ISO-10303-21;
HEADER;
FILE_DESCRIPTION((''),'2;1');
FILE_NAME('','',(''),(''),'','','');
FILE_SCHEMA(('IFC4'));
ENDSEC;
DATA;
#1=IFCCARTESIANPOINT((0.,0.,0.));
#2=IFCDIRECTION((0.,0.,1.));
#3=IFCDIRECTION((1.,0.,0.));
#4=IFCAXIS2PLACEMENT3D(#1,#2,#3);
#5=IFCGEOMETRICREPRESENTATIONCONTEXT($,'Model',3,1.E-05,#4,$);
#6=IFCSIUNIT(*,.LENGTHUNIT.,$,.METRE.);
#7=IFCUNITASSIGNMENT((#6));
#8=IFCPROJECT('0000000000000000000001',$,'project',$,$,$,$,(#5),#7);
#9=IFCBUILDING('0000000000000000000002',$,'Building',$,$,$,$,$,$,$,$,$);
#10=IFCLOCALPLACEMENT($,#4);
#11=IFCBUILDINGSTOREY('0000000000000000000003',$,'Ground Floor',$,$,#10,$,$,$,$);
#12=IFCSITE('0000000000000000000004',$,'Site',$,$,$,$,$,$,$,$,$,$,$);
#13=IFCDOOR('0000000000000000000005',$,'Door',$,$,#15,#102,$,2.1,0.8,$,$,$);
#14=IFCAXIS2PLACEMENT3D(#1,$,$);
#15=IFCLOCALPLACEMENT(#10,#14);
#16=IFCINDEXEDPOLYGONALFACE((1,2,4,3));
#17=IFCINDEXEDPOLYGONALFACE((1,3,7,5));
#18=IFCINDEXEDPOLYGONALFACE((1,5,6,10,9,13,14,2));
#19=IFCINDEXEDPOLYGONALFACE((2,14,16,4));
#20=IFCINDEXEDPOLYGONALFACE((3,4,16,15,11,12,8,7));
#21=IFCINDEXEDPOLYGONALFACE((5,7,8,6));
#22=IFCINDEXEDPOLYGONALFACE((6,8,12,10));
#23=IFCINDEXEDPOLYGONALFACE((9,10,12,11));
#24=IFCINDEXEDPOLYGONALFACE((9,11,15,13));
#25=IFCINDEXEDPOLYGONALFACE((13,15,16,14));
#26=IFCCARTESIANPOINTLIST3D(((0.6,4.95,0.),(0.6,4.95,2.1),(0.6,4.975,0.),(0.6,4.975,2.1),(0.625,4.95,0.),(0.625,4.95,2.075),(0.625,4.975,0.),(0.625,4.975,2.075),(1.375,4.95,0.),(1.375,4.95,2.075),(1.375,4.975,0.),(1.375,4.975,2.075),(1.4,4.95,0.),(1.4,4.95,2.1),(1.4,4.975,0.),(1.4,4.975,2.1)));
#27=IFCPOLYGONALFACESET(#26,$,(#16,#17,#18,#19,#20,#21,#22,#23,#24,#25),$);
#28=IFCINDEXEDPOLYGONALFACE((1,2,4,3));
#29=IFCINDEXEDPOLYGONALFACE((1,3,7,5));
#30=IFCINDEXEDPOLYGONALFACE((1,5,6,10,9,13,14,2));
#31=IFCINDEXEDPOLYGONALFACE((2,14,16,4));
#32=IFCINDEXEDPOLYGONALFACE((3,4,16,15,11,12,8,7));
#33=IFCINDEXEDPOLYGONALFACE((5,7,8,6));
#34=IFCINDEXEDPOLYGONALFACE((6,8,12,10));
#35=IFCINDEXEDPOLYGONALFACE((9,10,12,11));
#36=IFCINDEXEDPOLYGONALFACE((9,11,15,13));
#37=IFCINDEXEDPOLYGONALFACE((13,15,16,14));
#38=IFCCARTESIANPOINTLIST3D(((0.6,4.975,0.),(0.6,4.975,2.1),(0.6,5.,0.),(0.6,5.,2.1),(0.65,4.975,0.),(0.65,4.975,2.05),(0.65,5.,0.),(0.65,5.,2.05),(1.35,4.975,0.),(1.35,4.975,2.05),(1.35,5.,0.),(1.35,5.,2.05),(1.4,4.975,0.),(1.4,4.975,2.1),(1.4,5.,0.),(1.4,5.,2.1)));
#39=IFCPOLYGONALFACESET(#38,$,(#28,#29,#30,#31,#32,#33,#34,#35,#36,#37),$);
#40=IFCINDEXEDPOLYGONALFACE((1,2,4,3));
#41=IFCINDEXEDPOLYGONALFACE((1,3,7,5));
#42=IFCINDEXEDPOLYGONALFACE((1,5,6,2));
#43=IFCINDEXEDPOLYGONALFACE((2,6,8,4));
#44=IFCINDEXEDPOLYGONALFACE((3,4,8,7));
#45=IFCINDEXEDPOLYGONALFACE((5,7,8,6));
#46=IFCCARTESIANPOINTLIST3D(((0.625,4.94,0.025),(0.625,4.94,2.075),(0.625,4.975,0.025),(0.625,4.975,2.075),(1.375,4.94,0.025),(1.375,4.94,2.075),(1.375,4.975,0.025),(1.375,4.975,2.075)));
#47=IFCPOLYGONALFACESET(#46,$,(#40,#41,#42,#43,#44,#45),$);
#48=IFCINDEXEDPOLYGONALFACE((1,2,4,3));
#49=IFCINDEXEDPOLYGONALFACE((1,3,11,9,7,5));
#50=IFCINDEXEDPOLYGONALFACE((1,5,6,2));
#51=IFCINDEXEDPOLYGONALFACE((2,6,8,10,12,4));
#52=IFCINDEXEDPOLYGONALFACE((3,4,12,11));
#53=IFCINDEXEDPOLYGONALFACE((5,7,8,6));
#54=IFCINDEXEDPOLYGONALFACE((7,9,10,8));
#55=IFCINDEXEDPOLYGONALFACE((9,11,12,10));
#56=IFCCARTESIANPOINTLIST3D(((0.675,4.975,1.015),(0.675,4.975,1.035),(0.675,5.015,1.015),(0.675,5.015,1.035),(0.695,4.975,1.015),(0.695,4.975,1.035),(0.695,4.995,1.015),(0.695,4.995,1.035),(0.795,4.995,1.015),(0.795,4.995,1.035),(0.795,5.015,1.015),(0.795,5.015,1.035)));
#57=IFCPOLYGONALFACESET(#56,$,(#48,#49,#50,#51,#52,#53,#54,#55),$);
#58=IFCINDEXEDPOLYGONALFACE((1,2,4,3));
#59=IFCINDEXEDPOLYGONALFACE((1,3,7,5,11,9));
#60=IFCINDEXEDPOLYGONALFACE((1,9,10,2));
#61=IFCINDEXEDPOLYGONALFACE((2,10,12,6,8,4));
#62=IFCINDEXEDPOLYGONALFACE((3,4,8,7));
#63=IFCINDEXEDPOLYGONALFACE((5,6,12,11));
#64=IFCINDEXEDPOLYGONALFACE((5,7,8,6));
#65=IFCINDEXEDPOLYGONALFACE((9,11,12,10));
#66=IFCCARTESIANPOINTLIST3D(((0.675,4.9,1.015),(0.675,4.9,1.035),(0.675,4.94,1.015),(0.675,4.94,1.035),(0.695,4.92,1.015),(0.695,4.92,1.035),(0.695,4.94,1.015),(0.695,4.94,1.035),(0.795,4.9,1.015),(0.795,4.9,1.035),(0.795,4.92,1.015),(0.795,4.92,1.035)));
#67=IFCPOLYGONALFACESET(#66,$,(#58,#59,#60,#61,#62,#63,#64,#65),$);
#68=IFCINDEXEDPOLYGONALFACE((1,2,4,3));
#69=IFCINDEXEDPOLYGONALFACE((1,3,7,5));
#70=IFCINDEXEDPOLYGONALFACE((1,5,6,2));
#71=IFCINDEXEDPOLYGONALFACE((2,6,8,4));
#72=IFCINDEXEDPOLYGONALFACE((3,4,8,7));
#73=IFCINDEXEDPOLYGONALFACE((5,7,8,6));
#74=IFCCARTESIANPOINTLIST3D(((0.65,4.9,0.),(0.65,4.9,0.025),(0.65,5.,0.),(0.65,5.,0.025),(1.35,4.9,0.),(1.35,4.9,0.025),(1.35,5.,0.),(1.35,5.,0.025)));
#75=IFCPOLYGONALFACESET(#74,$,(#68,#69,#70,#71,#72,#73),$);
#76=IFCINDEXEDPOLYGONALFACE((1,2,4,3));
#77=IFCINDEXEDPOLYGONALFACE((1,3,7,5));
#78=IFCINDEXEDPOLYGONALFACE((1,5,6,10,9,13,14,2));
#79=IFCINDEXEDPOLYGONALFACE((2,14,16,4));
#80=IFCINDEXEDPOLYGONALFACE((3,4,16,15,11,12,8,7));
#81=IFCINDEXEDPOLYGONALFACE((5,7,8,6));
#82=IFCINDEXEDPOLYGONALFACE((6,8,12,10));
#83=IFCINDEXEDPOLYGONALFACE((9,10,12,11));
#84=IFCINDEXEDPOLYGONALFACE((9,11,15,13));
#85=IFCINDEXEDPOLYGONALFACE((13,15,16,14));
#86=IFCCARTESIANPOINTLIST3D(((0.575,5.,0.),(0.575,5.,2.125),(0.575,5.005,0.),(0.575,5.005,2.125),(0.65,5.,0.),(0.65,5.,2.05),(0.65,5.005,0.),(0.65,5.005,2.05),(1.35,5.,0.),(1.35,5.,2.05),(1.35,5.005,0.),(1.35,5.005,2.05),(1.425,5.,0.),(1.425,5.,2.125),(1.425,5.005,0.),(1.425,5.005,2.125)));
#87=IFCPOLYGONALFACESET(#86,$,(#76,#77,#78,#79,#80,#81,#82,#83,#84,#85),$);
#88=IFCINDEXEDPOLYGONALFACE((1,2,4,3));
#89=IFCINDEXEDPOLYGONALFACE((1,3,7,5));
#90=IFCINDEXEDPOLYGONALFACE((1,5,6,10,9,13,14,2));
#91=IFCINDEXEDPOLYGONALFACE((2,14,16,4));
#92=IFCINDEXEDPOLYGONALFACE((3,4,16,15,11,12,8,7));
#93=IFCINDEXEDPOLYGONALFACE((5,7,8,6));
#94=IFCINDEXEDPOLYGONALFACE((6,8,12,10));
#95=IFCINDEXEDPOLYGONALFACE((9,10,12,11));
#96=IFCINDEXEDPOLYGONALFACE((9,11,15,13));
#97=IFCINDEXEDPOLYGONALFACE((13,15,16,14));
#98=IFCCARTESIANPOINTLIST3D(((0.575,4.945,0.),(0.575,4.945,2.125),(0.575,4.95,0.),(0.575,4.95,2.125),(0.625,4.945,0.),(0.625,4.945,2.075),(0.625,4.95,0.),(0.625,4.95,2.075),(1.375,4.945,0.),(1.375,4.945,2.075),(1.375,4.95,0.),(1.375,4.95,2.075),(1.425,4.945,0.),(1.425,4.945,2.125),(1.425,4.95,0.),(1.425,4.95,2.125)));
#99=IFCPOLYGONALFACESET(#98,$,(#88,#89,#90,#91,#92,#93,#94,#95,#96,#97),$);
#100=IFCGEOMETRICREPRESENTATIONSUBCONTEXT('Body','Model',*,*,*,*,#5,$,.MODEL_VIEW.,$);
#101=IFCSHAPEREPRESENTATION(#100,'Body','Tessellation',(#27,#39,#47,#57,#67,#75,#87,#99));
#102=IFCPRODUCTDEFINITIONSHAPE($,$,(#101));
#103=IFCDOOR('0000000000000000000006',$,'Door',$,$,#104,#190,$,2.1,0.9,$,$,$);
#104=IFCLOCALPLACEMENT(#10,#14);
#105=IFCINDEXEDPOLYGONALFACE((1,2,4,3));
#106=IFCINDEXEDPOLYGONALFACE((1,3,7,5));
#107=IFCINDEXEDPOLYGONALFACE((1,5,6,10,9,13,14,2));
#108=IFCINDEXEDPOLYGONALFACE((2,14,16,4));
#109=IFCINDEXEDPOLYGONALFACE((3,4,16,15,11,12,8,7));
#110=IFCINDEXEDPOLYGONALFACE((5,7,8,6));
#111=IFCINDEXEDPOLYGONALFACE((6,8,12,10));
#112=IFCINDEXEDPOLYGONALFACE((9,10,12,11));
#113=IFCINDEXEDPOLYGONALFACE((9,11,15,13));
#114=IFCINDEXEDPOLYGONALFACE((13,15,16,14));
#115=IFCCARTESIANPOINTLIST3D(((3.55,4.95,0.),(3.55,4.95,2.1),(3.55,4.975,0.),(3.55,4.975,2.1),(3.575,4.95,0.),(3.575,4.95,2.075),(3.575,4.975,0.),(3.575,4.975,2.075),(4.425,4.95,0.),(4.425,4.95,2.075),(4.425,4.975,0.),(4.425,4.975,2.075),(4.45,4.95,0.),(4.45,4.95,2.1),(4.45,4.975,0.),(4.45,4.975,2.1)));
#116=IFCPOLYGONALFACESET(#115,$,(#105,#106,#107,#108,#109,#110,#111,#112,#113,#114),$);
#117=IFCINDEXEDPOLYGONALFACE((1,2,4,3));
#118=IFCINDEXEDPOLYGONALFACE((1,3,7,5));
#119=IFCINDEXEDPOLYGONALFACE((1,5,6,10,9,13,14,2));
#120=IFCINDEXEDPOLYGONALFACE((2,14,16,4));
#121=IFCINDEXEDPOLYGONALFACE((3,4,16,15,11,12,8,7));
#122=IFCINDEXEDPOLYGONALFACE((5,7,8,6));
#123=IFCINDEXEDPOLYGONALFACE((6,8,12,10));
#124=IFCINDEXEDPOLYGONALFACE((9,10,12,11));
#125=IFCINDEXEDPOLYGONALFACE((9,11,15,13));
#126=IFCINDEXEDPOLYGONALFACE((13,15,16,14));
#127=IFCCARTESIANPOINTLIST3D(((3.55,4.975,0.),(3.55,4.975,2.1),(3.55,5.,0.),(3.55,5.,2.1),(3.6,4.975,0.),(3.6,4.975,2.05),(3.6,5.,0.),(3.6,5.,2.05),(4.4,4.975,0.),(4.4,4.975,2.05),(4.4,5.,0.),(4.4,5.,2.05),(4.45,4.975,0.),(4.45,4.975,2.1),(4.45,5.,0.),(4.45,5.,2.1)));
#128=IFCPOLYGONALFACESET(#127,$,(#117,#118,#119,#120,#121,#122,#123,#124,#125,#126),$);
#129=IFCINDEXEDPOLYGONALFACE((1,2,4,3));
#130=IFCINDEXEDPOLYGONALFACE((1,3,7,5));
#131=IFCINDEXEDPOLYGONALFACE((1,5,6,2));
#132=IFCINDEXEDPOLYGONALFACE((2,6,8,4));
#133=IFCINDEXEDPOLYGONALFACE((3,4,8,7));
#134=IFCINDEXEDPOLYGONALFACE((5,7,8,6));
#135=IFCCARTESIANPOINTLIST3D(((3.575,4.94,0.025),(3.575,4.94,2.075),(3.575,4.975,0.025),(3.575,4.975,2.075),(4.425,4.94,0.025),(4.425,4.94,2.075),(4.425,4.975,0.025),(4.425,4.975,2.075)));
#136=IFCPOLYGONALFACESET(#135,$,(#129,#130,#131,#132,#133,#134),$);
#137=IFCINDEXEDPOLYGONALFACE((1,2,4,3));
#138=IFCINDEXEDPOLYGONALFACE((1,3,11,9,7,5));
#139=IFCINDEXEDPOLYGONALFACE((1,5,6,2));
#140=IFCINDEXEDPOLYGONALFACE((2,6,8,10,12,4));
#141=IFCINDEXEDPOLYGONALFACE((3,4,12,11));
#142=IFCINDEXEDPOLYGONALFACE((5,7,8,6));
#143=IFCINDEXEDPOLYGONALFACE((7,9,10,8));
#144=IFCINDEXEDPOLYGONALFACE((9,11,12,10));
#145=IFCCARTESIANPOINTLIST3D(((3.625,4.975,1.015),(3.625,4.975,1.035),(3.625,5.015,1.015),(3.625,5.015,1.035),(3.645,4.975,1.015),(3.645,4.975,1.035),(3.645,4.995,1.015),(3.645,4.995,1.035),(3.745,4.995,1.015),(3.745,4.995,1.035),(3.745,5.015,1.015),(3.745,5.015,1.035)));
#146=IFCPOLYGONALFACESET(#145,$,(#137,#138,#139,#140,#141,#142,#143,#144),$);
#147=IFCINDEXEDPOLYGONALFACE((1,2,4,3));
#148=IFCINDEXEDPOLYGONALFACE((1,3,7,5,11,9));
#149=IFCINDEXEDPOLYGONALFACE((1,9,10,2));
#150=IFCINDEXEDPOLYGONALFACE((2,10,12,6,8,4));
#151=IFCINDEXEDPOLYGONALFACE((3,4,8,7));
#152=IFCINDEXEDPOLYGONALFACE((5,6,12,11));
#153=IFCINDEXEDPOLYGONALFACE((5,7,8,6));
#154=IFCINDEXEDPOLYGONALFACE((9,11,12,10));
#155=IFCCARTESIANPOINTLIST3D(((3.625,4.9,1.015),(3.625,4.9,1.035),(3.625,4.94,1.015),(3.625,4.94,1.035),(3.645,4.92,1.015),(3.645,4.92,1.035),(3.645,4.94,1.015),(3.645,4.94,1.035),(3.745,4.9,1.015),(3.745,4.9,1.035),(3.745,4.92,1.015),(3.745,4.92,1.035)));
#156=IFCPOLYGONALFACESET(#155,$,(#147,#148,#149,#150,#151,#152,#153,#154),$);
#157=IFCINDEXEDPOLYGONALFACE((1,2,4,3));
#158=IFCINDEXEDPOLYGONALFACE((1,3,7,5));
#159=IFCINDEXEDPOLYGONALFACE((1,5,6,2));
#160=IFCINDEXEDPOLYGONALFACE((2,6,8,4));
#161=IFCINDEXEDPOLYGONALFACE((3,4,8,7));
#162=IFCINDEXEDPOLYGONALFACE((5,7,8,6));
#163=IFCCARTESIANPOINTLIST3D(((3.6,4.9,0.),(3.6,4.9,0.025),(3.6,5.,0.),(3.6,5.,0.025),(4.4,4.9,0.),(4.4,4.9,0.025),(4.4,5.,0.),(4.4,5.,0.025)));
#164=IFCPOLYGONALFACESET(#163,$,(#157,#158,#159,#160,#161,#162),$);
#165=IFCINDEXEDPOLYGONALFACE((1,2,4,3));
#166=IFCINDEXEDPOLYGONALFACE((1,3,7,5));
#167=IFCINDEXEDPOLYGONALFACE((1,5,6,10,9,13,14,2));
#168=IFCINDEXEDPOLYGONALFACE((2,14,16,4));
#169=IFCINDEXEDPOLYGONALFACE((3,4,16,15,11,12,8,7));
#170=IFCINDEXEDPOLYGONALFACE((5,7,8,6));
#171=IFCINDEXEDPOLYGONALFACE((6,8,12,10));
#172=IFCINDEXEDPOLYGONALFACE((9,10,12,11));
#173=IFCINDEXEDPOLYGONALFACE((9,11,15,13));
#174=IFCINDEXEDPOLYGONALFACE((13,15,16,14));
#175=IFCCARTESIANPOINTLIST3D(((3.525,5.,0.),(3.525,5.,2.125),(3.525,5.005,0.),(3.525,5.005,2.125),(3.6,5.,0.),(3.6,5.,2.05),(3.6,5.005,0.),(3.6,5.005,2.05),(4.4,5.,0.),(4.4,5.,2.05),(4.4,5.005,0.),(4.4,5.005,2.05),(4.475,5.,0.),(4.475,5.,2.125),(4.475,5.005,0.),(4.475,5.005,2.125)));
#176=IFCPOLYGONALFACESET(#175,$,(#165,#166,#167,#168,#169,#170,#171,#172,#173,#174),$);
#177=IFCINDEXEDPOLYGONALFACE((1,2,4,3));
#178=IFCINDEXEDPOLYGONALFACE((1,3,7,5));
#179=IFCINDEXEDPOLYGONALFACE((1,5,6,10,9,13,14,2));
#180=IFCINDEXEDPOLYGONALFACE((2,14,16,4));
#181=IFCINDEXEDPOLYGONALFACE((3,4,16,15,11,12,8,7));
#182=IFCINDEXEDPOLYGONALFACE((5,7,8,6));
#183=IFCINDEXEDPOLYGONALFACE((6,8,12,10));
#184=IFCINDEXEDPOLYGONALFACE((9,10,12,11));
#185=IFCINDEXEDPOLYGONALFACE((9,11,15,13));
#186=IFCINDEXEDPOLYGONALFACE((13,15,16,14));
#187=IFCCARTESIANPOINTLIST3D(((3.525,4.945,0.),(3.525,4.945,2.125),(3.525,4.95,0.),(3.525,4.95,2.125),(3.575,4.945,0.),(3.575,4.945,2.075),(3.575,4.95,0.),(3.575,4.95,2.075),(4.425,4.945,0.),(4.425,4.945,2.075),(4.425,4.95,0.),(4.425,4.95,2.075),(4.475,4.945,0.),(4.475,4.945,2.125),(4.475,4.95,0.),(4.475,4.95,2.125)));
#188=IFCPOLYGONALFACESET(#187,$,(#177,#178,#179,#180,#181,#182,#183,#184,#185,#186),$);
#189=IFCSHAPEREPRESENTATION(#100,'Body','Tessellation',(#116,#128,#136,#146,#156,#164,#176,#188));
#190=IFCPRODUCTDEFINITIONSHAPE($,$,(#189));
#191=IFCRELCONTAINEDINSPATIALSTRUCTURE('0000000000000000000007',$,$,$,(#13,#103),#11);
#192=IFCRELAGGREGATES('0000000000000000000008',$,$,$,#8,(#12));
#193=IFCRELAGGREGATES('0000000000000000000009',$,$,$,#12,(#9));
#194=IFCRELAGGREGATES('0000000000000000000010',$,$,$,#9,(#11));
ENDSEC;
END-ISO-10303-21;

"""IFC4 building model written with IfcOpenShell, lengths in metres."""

from ifc_helpers import new_model, si_unit, frame, origin_with_axes, place, context, subcontext, project, spatial, line, indexed_curve, outline, extrude, element, save


model = new_model("IFC4")

# Units and contexts
model_context = context("Model", 3, precision=1e-05, world=origin_with_axes())
body_context = subcontext(model_context, "Body", "Model", "MODEL_VIEW")
ifc_project = project(units=[si_unit("LENGTHUNIT", "METRE")], contexts=[model_context])

# Site, building, storey
site = spatial("IfcSite", under=ifc_project, Name="Site")
building = spatial("IfcBuilding", under=site, Name="Building")
storey_placement = place(None, origin_with_axes())
storey = spatial("IfcBuildingStorey", under=building, at=storey_placement, Name="Ground Floor")

# Doors
door_1_placement = place(storey_placement, frame((1.4, 5.0, 0.0), z_axis=(0.0, 0.0, 1.0), x_axis=(-1.0, 0.0, 0.0)))
element("IfcDoor", 1, at=door_1_placement, inside=storey, Name="Door", OverallHeight=2.1, OverallWidth=0.8, context=body_context, shape_type="SweptSolid", body=[
    extrude(outline(indexed_curve([(0.0, 0.0), (0.0, 2.1), (0.8, 2.1), (0.8, 0.0), (0.775, 0.0), (0.775, 2.075), (0.025, 2.075), (0.025, 0.0)], segments=[line(1, 2, 3, 4, 5, 6, 7, 8, 1)])), frame((0.0, 0.025, 0.0), z_axis=(0.0, -1.0, 0.0), x_axis=(1.0, 0.0, 0.0)), (0.0, 0.0, -1.0), 0.025),
    extrude(outline(indexed_curve([(0.0, 0.0), (0.0, 2.1), (0.8, 2.1), (0.8, 0.0), (0.75, 0.0), (0.75, 2.05), (0.05, 2.05), (0.05, 0.0)], segments=[line(1, 2, 3, 4, 5, 6, 7, 8, 1)])), frame((0.0, 0.0, 0.0), z_axis=(0.0, -1.0, 0.0), x_axis=(1.0, 0.0, 0.0)), (0.0, 0.0, -1.0), 0.025),
    extrude(outline(indexed_curve([(0.0, 0.0), (0.75, 0.0), (0.75, 0.035), (0.0, 0.035)], segments=[line(1, 2, 3, 4, 1)])), frame((0.025, 0.025, 0.025), z_axis=(0.0, 0.0, 1.0), x_axis=(1.0, 0.0, 0.0)), (0.0, 0.0, 1.0), 2.05),
    extrude(outline(indexed_curve([(0.0, 0.0), (0.0, -0.04), (-0.12, -0.04), (-0.12, -0.02), (-0.02, -0.02), (-0.02, 0.0)], segments=[line(1, 2, 3, 4, 5, 6, 1)])), frame((0.725, 0.025, 1.015), z_axis=(0.0, 0.0, 1.0), x_axis=(1.0, 0.0, 0.0)), (0.0, 0.0, 1.0), 0.02),
    extrude(outline(indexed_curve([(0.0, 0.0), (0.0, 0.04), (-0.12, 0.04), (-0.12, 0.02), (-0.02, 0.02), (-0.02, 0.0)], segments=[line(1, 2, 3, 4, 5, 6, 1)])), frame((0.725, 0.06, 1.015), z_axis=(0.0, 0.0, 1.0), x_axis=(1.0, 0.0, 0.0)), (0.0, 0.0, 1.0), 0.02),
    extrude(outline(indexed_curve([(0.0, 0.0), (0.7, 0.0), (0.7, 0.1), (0.0, 0.1)], segments=[line(1, 2, 3, 4, 1)])), frame((0.05, 0.0, 0.0), z_axis=(0.0, 0.0, 1.0), x_axis=(1.0, 0.0, 0.0)), (0.0, 0.0, 1.0), 0.025),
    extrude(outline(indexed_curve([(0.0, 0.0), (0.0, 2.125), (0.85, 2.125), (0.85, 0.0), (0.775, 0.0), (0.775, 2.05), (0.075, 2.05), (0.075, 0.0)], segments=[line(1, 2, 3, 4, 5, 6, 7, 8, 1)])), frame((-0.025, -0.005, 0.0), z_axis=(0.0, -1.0, 0.0), x_axis=(1.0, 0.0, 0.0)), (0.0, 0.0, -1.0), 0.005),
    extrude(outline(indexed_curve([(0.0, 0.0), (0.0, 2.125), (0.85, 2.125), (0.85, 0.0), (0.8, 0.0), (0.8, 2.075), (0.05, 2.075), (0.05, 0.0)], segments=[line(1, 2, 3, 4, 5, 6, 7, 8, 1)])), frame((-0.025, 0.05, 0.0), z_axis=(0.0, -1.0, 0.0), x_axis=(1.0, 0.0, 0.0)), (0.0, 0.0, -1.0), 0.005),
])
door_2_placement = place(storey_placement, frame((4.45, 5.0, 0.0), z_axis=(0.0, 0.0, 1.0), x_axis=(-1.0, 0.0, 0.0)))
element("IfcDoor", 2, at=door_2_placement, inside=storey, Name="Door", OverallHeight=2.1, OverallWidth=0.9, context=body_context, shape_type="SweptSolid", body=[
    extrude(outline(indexed_curve([(0.0, 0.0), (0.0, 2.1), (0.9, 2.1), (0.9, 0.0), (0.875, 0.0), (0.875, 2.075), (0.025, 2.075), (0.025, 0.0)], segments=[line(1, 2, 3, 4, 5, 6, 7, 8, 1)])), frame((0.0, 0.025, 0.0), z_axis=(0.0, -1.0, 0.0), x_axis=(1.0, 0.0, 0.0)), (0.0, 0.0, -1.0), 0.025),
    extrude(outline(indexed_curve([(0.0, 0.0), (0.0, 2.1), (0.9, 2.1), (0.9, 0.0), (0.85, 0.0), (0.85, 2.05), (0.05, 2.05), (0.05, 0.0)], segments=[line(1, 2, 3, 4, 5, 6, 7, 8, 1)])), frame((0.0, 0.0, 0.0), z_axis=(0.0, -1.0, 0.0), x_axis=(1.0, 0.0, 0.0)), (0.0, 0.0, -1.0), 0.025),
    extrude(outline(indexed_curve([(0.0, 0.0), (0.85, 0.0), (0.85, 0.035), (0.0, 0.035)], segments=[line(1, 2, 3, 4, 1)])), frame((0.025, 0.025, 0.025), z_axis=(0.0, 0.0, 1.0), x_axis=(1.0, 0.0, 0.0)), (0.0, 0.0, 1.0), 2.05),
    extrude(outline(indexed_curve([(0.0, 0.0), (0.0, -0.04), (-0.12, -0.04), (-0.12, -0.02), (-0.02, -0.02), (-0.02, 0.0)], segments=[line(1, 2, 3, 4, 5, 6, 1)])), frame((0.825, 0.025, 1.015), z_axis=(0.0, 0.0, 1.0), x_axis=(1.0, 0.0, 0.0)), (0.0, 0.0, 1.0), 0.02),
    extrude(outline(indexed_curve([(0.0, 0.0), (0.0, 0.04), (-0.12, 0.04), (-0.12, 0.02), (-0.02, 0.02), (-0.02, 0.0)], segments=[line(1, 2, 3, 4, 5, 6, 1)])), frame((0.825, 0.06, 1.015), z_axis=(0.0, 0.0, 1.0), x_axis=(1.0, 0.0, 0.0)), (0.0, 0.0, 1.0), 0.02),
    extrude(outline(indexed_curve([(0.0, 0.0), (0.8, 0.0), (0.8, 0.1), (0.0, 0.1)], segments=[line(1, 2, 3, 4, 1)])), frame((0.05, 0.0, 0.0), z_axis=(0.0, 0.0, 1.0), x_axis=(1.0, 0.0, 0.0)), (0.0, 0.0, 1.0), 0.025),
    extrude(outline(indexed_curve([(0.0, 0.0), (0.0, 2.125), (0.95, 2.125), (0.95, 0.0), (0.875, 0.0), (0.875, 2.05), (0.075, 2.05), (0.075, 0.0)], segments=[line(1, 2, 3, 4, 5, 6, 7, 8, 1)])), frame((-0.025, -0.005, 0.0), z_axis=(0.0, -1.0, 0.0), x_axis=(1.0, 0.0, 0.0)), (0.0, 0.0, -1.0), 0.005),
    extrude(outline(indexed_curve([(0.0, 0.0), (0.0, 2.125), (0.95, 2.125), (0.95, 0.0), (0.9, 0.0), (0.9, 2.075), (0.05, 2.075), (0.05, 0.0)], segments=[line(1, 2, 3, 4, 5, 6, 7, 8, 1)])), frame((-0.025, 0.05, 0.0), z_axis=(0.0, -1.0, 0.0), x_axis=(1.0, 0.0, 0.0)), (0.0, 0.0, -1.0), 0.005),
])

save(model, "model.ifc")
